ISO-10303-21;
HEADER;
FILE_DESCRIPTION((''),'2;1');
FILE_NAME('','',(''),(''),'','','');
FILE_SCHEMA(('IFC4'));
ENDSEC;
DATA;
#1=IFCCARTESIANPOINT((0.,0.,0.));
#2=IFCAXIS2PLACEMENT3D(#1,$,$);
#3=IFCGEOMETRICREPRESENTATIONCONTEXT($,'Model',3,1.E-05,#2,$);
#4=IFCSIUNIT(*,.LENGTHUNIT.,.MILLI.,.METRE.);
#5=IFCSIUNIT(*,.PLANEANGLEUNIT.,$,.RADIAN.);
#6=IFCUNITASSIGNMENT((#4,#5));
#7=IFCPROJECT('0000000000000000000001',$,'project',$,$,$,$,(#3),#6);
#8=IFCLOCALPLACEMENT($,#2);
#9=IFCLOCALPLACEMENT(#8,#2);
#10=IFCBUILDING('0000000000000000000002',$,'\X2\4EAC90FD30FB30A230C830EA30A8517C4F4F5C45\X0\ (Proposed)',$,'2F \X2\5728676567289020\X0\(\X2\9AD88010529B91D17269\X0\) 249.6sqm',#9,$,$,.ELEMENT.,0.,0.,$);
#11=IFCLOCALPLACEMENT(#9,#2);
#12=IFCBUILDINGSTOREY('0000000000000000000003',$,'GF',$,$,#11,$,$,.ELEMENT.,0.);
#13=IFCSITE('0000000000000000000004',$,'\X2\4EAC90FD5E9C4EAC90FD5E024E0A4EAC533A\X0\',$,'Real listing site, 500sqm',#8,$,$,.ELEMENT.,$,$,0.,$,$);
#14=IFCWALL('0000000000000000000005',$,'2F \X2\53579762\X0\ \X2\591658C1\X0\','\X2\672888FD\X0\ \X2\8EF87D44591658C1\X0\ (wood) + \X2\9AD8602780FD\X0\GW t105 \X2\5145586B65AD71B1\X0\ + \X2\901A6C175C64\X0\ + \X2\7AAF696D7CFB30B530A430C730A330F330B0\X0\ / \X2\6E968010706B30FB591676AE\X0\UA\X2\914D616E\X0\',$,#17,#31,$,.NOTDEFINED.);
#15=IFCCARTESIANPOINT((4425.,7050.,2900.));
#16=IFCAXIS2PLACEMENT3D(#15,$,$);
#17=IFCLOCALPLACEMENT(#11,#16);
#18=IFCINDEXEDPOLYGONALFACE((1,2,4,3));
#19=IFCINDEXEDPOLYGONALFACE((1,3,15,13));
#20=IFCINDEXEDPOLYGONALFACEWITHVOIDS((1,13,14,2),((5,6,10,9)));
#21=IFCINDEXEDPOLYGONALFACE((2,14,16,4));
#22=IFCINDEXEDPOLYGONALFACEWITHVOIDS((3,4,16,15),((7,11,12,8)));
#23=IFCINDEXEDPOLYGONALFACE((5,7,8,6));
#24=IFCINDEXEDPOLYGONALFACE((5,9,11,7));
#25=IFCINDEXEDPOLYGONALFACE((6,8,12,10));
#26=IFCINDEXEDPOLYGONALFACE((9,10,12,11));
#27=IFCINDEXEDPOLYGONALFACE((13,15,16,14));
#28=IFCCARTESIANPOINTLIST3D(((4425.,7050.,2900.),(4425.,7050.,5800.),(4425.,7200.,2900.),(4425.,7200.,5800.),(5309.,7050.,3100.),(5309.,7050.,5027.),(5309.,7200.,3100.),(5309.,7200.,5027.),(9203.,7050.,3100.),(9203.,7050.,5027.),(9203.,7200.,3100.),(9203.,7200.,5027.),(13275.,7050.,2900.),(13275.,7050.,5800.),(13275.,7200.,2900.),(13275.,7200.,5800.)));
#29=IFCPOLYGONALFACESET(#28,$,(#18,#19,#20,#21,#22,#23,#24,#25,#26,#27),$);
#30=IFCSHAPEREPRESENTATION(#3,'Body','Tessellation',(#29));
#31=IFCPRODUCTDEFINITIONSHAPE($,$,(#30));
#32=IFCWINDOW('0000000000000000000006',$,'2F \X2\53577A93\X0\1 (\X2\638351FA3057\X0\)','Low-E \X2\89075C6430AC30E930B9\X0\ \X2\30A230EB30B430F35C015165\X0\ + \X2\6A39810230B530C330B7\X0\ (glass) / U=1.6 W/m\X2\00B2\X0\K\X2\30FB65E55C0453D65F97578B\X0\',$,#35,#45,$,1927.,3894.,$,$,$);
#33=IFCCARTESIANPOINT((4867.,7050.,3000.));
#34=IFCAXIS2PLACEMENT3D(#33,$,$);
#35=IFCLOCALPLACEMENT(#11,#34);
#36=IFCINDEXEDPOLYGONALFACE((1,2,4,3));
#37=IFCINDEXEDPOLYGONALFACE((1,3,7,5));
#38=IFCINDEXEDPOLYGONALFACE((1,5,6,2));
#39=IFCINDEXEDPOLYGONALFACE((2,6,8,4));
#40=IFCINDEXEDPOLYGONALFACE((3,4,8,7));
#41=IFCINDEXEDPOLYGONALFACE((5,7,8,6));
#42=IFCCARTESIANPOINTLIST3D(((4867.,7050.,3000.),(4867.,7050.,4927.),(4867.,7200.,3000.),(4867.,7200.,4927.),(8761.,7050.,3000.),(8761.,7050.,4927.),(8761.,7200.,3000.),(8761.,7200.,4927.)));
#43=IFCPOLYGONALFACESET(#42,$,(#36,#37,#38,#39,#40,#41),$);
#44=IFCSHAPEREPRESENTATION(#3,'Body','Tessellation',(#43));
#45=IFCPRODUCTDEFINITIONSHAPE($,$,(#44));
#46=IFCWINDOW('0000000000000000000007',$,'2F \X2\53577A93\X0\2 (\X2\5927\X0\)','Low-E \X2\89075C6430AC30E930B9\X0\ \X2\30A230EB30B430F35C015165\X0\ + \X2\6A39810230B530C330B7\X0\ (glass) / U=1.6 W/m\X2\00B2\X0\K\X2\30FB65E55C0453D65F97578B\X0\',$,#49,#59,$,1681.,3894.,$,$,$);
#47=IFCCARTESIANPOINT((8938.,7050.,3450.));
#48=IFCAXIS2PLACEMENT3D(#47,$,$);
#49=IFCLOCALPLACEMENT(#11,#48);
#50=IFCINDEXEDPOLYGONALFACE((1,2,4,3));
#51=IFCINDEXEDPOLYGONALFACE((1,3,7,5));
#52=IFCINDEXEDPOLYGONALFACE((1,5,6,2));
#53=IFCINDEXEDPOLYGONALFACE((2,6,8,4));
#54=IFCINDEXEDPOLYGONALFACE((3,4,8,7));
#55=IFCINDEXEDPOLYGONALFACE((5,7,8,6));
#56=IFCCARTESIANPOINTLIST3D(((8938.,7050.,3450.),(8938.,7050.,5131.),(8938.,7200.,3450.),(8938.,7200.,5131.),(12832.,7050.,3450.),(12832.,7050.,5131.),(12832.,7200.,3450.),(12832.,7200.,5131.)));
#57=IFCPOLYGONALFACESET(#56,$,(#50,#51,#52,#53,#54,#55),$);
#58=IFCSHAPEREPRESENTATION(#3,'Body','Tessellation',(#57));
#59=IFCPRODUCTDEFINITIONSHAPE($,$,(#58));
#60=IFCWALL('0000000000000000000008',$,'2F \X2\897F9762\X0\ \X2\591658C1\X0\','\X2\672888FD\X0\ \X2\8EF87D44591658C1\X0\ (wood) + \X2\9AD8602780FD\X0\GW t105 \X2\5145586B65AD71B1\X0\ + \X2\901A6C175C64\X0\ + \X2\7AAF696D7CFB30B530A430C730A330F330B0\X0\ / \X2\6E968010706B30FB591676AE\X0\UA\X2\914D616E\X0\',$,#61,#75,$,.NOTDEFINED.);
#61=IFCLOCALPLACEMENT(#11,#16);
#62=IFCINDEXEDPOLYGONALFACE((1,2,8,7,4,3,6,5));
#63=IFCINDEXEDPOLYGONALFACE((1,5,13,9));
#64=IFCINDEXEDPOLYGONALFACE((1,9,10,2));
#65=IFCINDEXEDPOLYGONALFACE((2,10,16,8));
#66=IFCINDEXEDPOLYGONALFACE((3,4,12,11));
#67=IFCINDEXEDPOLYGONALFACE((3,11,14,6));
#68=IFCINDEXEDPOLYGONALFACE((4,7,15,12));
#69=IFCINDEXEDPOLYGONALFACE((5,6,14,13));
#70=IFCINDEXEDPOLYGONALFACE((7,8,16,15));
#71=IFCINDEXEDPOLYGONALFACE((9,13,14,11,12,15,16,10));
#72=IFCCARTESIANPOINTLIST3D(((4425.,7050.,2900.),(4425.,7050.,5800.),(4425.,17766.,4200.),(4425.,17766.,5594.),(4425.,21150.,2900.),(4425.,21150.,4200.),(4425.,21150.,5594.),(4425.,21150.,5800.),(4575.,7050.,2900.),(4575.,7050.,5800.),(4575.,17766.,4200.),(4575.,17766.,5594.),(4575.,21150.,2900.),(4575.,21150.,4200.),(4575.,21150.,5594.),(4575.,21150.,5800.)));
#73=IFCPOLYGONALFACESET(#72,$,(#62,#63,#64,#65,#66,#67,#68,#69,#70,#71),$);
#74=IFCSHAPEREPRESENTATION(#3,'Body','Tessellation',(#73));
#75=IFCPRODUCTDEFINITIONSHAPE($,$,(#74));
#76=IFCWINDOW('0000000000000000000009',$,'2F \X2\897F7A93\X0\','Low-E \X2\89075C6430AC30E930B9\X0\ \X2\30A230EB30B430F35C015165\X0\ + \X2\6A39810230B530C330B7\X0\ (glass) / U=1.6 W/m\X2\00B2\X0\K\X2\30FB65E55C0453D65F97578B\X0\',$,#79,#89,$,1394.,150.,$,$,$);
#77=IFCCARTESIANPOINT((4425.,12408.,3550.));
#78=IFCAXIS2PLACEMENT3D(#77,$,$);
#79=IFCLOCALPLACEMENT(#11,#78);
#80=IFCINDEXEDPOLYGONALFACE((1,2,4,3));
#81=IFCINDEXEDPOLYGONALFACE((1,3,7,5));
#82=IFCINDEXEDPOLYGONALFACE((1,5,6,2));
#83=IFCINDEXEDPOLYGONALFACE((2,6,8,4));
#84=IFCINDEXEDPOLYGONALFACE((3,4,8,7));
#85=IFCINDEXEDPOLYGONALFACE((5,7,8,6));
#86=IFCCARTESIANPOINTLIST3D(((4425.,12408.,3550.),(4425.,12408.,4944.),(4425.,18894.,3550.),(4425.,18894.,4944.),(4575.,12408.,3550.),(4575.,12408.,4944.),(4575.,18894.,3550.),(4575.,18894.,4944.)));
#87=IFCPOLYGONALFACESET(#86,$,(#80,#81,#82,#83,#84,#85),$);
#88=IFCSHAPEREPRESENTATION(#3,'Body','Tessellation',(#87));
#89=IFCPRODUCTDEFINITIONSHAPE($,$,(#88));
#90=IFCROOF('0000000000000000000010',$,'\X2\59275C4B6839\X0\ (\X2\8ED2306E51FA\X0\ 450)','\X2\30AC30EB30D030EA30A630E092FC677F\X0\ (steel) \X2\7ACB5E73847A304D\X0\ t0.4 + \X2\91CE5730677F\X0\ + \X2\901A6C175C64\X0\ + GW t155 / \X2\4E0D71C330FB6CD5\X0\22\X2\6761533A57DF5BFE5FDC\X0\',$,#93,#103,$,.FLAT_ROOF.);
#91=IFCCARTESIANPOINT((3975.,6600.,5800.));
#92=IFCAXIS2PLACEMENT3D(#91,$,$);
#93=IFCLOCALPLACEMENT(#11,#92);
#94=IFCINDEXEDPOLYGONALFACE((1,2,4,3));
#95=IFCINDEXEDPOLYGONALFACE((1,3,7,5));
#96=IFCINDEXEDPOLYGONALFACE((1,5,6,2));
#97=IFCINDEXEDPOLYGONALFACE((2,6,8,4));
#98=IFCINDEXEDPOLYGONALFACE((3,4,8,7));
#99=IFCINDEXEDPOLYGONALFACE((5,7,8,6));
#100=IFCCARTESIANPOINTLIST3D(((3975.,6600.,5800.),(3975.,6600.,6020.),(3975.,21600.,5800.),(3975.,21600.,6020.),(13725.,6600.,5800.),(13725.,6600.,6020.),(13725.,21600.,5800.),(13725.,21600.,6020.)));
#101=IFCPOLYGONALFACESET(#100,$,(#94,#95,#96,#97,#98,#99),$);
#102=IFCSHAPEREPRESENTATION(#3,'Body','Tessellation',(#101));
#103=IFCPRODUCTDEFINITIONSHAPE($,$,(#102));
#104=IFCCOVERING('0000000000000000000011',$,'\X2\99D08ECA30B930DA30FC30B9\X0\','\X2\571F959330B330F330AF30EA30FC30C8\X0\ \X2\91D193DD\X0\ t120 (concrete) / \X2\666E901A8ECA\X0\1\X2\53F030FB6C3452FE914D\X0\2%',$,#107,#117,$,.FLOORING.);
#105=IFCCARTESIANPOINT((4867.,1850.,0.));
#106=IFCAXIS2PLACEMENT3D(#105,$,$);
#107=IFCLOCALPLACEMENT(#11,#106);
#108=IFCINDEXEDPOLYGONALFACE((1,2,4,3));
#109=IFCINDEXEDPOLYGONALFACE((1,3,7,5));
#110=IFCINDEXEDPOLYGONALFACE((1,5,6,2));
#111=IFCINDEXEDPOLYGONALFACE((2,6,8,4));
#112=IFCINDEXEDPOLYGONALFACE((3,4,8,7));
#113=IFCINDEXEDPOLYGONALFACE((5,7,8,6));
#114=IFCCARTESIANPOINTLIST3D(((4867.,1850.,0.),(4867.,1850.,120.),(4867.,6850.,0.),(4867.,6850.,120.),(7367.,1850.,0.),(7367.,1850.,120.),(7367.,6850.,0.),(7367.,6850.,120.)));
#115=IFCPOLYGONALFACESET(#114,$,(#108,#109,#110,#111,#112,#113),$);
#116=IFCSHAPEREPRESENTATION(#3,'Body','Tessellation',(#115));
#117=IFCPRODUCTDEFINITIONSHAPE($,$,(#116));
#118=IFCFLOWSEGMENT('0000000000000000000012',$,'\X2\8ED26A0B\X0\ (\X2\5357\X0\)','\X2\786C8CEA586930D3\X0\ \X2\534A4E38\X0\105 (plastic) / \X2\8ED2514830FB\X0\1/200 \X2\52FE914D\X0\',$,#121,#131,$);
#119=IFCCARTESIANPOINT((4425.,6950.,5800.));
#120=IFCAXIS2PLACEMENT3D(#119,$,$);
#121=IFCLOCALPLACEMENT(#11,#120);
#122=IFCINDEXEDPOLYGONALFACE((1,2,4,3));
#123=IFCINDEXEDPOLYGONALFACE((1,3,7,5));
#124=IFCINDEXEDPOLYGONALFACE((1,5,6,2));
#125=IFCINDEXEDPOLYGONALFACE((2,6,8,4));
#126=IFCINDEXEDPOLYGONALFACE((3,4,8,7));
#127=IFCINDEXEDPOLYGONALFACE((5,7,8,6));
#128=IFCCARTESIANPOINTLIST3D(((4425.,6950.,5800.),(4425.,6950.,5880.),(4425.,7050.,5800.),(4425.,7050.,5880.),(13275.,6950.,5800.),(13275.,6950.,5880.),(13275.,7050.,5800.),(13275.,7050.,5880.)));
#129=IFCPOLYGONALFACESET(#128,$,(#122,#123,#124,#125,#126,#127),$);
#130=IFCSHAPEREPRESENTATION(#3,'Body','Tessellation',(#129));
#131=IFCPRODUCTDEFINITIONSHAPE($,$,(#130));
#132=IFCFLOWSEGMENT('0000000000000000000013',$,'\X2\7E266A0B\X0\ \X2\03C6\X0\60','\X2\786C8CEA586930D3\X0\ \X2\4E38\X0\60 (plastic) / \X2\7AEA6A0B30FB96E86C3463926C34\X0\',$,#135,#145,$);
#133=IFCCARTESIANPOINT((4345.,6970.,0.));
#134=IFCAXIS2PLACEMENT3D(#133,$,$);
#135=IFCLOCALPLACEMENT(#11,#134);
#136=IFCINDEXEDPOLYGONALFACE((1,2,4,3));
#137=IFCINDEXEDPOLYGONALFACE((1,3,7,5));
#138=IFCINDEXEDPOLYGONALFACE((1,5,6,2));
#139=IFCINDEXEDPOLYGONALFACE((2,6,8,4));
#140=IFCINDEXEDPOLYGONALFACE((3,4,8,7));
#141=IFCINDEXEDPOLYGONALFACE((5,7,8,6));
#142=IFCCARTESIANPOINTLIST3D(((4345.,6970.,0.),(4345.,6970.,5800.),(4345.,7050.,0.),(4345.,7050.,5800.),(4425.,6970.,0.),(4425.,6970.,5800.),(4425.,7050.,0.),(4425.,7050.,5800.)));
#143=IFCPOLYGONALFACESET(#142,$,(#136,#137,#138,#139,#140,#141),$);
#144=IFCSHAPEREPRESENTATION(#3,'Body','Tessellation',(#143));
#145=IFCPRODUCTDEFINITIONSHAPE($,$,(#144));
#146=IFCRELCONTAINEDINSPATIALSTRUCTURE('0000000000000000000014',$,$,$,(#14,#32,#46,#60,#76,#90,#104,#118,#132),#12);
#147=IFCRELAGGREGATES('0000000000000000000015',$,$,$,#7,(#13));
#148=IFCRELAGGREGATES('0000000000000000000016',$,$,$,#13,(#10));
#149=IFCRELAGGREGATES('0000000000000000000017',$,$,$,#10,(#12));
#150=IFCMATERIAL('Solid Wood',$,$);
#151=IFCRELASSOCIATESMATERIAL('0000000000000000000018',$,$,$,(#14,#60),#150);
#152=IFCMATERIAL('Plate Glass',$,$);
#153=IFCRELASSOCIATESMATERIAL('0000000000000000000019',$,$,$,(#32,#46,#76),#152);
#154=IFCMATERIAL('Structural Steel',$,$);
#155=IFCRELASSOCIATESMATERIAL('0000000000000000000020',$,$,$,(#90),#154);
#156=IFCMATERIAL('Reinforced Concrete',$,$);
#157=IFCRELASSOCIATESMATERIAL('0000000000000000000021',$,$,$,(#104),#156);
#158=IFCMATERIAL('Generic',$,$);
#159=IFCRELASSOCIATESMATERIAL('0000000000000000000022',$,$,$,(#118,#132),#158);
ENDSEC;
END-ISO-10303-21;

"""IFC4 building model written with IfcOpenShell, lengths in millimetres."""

from ifc_helpers import new_model, si_unit, frame, frame_2d, origin, place, context, project, spatial, rectangle, extrude, material, element, fill, save


model = new_model("IFC4")

# Units and contexts
model_context = context("Model", 3, precision=1e-05, world=origin())
ifc_project = project(units=[si_unit("LENGTHUNIT", "METRE", prefix="MILLI"), si_unit("PLANEANGLEUNIT", "RADIAN")], contexts=[model_context])

# Site, building, storey
site_placement = place(None, origin())
site = spatial("IfcSite", under=ifc_project, at=site_placement, Name="京都府京都市上京区", ObjectType="Real listing site, 500sqm", CompositionType="ELEMENT", RefElevation=0.0)
building_placement = place(site_placement, origin())
building = spatial("IfcBuilding", under=site, at=building_placement, Name="京都・アトリエ兼住居 (Proposed)", ObjectType="2F 在来木造(高耐力金物) 249.6sqm", CompositionType="ELEMENT", ElevationOfRefHeight=0.0, ElevationOfTerrain=0.0)
storey_placement = place(building_placement, origin())
storey = spatial("IfcBuildingStorey", under=building, at=storey_placement, Name="GF", CompositionType="ELEMENT", Elevation=0.0)

# Shared definitions
ifc_material_1 = material(Name="Solid Wood")

# Shared definitions
ifc_material_2 = material(Name="Reinforced Concrete")

# Shared definitions
ifc_material_3 = material(Name="Plate Glass")

# Wall, openings, windows
wall_1_placement = place(storey_placement, frame((4425.0, 7050.0, 2900.0)))
wall_1 = element("IfcWall", 1, at=wall_1_placement, inside=storey, material=ifc_material_1, Name="2F 南面 外壁", Description="木製 軸組外壁 (wood) + 高性能GW t105 充填断熱 + 通気層 + 窯業系サイディング / 準耐火・外皮UA配慮", PredefinedType="NOTDEFINED", context=model_context, shape_type="SweptSolid", body=[
    extrude(rectangle(XDim=8850.0, YDim=150.0, at=frame_2d((4425.0, 75.0))), frame((4425.0, 7050.0, 2900.0)), (0.0, 0.0, 1.0), 2900.0),
])
opening_1_placement = place(storey_placement, frame((4867.0, 7050.0, 3000.0)))
opening_1 = element("IfcOpeningElement", 2, at=opening_1_placement, cuts=wall_1, PredefinedType="NOTDEFINED", context=model_context, shape_type="SweptSolid", body=[
    extrude(rectangle(XDim=3894.0, YDim=150.0, at=frame_2d((1947.0, 75.0))), frame((4867.0, 7050.0, 3000.0)), (0.0, 0.0, 1.0), 1927.0),
])
opening_2_placement = place(storey_placement, frame((8938.0, 7050.0, 3450.0)))
opening_2 = element("IfcOpeningElement", 3, at=opening_2_placement, cuts=wall_1, PredefinedType="NOTDEFINED", context=model_context, shape_type="SweptSolid", body=[
    extrude(rectangle(XDim=3894.0, YDim=150.0, at=frame_2d((1947.0, 75.0))), frame((8938.0, 7050.0, 3450.0)), (0.0, 0.0, 1.0), 1681.0),
])
window_1_placement = place(storey_placement, frame((4867.0, 7050.0, 3000.0)))
window_1 = element("IfcWindow", 4, at=window_1_placement, inside=storey, material=ifc_material_3, Name="2F 南窓1 (掃出し)", Description="Low-E 複層ガラス アルゴン封入 + 樹脂サッシ (glass) / U=1.6 W/m²K・日射取得型", OverallHeight=1927.0, OverallWidth=3894.0, context=model_context, shape_type="SweptSolid", body=[
    extrude(rectangle(XDim=3894.0, YDim=150.0, at=frame_2d((1947.0, 75.0))), frame((4867.0, 7050.0, 3000.0)), (0.0, 0.0, 1.0), 1927.0),
])
fill(opening_1, window_1)
window_2_placement = place(storey_placement, frame((8938.0, 7050.0, 3450.0)))
window_2 = element("IfcWindow", 5, at=window_2_placement, inside=storey, material=ifc_material_3, Name="2F 南窓2 (大)", Description="Low-E 複層ガラス アルゴン封入 + 樹脂サッシ (glass) / U=1.6 W/m²K・日射取得型", OverallHeight=1681.0, OverallWidth=3894.0, context=model_context, shape_type="SweptSolid", body=[
    extrude(rectangle(XDim=3894.0, YDim=150.0, at=frame_2d((1947.0, 75.0))), frame((8938.0, 7050.0, 3450.0)), (0.0, 0.0, 1.0), 1681.0),
])
fill(opening_2, window_2)

# Wall, opening, window
wall_2_placement = place(storey_placement, frame((4425.0, 7050.0, 2900.0)))
wall_2 = element("IfcWall", 6, at=wall_2_placement, inside=storey, material=ifc_material_1, Name="2F 西面 外壁", Description="木製 軸組外壁 (wood) + 高性能GW t105 充填断熱 + 通気層 + 窯業系サイディング / 準耐火・外皮UA配慮", PredefinedType="NOTDEFINED", context=model_context, shape_type="SweptSolid", body=[
    extrude(rectangle(XDim=150.0, YDim=14100.0, at=frame_2d((75.0, 7050.0))), frame((4425.0, 7050.0, 2900.0)), (0.0, 0.0, 1.0), 2900.0),
])
opening_3_placement = place(storey_placement, frame((4425.0, 12408.0, 3550.0)))
opening_3 = element("IfcOpeningElement", 7, at=opening_3_placement, cuts=wall_2, PredefinedType="NOTDEFINED", context=model_context, shape_type="SweptSolid", body=[
    extrude(rectangle(XDim=150.0, YDim=6486.0, at=frame_2d((75.0, 3243.0))), frame((4425.0, 12408.0, 3550.0)), (0.0, 0.0, 1.0), 1394.0),
])
window_3_placement = place(storey_placement, frame((4425.0, 12408.0, 3550.0)))
window_3 = element("IfcWindow", 8, at=window_3_placement, inside=storey, material=ifc_material_3, Name="2F 西窓", Description="Low-E 複層ガラス アルゴン封入 + 樹脂サッシ (glass) / U=1.6 W/m²K・日射取得型", OverallHeight=1394.0, OverallWidth=150.0, context=model_context, shape_type="SweptSolid", body=[
    extrude(rectangle(XDim=150.0, YDim=6486.0, at=frame_2d((75.0, 3243.0))), frame((4425.0, 12408.0, 3550.0)), (0.0, 0.0, 1.0), 1394.0),
])
fill(opening_3, window_3)

# Roof
ifc_material_4 = material(Name="Structural Steel")
roof_placement = place(storey_placement, frame((3975.0, 6600.0, 5800.0)))
element("IfcRoof", 9, at=roof_placement, inside=storey, material=ifc_material_4, Name="大屋根 (軒の出 450)", Description="ガルバリウム鋼板 (steel) 立平葺き t0.4 + 野地板 + 通気層 + GW t155 / 不燃・法22条区域対応", PredefinedType="FLAT_ROOF", context=model_context, shape_type="SweptSolid", body=[
    extrude(rectangle(XDim=9750.0, YDim=15000.0, at=frame_2d((4875.0, 7500.0))), frame((3975.0, 6600.0, 5800.0)), (0.0, 0.0, 1.0), 220.0),
])

# Covering
covering_placement = place(storey_placement, frame((4867.0, 1850.0, 0.0)))
element("IfcCovering", 10, at=covering_placement, inside=storey, material=ifc_material_2, Name="駐車スペース", Description="土間コンクリート 金鏝 t120 (concrete) / 普通車1台・水勾配2%", PredefinedType="FLOORING", context=model_context, shape_type="SweptSolid", body=[
    extrude(rectangle(XDim=2500.0, YDim=5000.0, at=frame_2d((1250.0, 2500.0))), frame((4867.0, 1850.0, 0.0)), (0.0, 0.0, 1.0), 120.0),
])

# Flow segments
ifc_material_5 = material(Name="Generic")
flow_segment_1_placement = place(storey_placement, frame((4425.0, 6950.0, 5800.0)))
element("IfcFlowSegment", 11, at=flow_segment_1_placement, inside=storey, material=ifc_material_5, Name="軒樋 (南)", Description="硬質塩ビ 半丸105 (plastic) / 軒先・1/200 勾配", context=model_context, shape_type="SweptSolid", body=[
    extrude(rectangle(XDim=8850.0, YDim=100.0, at=frame_2d((4425.0, 50.0))), frame((4425.0, 6950.0, 5800.0)), (0.0, 0.0, 1.0), 80.0),
])
flow_segment_2_placement = place(storey_placement, frame((4345.0, 6970.0, 0.0)))
element("IfcFlowSegment", 12, at=flow_segment_2_placement, inside=storey, material=ifc_material_5, Name="縦樋 φ60", Description="硬質塩ビ 丸60 (plastic) / 竪樋・雨水排水", context=model_context, shape_type="SweptSolid", body=[
    extrude(rectangle(XDim=80.0, YDim=80.0, at=frame_2d((40.0, 40.0))), frame((4345.0, 6970.0, 0.0)), (0.0, 0.0, 1.0), 5800.0),
])

save(model, "model.ifc")
